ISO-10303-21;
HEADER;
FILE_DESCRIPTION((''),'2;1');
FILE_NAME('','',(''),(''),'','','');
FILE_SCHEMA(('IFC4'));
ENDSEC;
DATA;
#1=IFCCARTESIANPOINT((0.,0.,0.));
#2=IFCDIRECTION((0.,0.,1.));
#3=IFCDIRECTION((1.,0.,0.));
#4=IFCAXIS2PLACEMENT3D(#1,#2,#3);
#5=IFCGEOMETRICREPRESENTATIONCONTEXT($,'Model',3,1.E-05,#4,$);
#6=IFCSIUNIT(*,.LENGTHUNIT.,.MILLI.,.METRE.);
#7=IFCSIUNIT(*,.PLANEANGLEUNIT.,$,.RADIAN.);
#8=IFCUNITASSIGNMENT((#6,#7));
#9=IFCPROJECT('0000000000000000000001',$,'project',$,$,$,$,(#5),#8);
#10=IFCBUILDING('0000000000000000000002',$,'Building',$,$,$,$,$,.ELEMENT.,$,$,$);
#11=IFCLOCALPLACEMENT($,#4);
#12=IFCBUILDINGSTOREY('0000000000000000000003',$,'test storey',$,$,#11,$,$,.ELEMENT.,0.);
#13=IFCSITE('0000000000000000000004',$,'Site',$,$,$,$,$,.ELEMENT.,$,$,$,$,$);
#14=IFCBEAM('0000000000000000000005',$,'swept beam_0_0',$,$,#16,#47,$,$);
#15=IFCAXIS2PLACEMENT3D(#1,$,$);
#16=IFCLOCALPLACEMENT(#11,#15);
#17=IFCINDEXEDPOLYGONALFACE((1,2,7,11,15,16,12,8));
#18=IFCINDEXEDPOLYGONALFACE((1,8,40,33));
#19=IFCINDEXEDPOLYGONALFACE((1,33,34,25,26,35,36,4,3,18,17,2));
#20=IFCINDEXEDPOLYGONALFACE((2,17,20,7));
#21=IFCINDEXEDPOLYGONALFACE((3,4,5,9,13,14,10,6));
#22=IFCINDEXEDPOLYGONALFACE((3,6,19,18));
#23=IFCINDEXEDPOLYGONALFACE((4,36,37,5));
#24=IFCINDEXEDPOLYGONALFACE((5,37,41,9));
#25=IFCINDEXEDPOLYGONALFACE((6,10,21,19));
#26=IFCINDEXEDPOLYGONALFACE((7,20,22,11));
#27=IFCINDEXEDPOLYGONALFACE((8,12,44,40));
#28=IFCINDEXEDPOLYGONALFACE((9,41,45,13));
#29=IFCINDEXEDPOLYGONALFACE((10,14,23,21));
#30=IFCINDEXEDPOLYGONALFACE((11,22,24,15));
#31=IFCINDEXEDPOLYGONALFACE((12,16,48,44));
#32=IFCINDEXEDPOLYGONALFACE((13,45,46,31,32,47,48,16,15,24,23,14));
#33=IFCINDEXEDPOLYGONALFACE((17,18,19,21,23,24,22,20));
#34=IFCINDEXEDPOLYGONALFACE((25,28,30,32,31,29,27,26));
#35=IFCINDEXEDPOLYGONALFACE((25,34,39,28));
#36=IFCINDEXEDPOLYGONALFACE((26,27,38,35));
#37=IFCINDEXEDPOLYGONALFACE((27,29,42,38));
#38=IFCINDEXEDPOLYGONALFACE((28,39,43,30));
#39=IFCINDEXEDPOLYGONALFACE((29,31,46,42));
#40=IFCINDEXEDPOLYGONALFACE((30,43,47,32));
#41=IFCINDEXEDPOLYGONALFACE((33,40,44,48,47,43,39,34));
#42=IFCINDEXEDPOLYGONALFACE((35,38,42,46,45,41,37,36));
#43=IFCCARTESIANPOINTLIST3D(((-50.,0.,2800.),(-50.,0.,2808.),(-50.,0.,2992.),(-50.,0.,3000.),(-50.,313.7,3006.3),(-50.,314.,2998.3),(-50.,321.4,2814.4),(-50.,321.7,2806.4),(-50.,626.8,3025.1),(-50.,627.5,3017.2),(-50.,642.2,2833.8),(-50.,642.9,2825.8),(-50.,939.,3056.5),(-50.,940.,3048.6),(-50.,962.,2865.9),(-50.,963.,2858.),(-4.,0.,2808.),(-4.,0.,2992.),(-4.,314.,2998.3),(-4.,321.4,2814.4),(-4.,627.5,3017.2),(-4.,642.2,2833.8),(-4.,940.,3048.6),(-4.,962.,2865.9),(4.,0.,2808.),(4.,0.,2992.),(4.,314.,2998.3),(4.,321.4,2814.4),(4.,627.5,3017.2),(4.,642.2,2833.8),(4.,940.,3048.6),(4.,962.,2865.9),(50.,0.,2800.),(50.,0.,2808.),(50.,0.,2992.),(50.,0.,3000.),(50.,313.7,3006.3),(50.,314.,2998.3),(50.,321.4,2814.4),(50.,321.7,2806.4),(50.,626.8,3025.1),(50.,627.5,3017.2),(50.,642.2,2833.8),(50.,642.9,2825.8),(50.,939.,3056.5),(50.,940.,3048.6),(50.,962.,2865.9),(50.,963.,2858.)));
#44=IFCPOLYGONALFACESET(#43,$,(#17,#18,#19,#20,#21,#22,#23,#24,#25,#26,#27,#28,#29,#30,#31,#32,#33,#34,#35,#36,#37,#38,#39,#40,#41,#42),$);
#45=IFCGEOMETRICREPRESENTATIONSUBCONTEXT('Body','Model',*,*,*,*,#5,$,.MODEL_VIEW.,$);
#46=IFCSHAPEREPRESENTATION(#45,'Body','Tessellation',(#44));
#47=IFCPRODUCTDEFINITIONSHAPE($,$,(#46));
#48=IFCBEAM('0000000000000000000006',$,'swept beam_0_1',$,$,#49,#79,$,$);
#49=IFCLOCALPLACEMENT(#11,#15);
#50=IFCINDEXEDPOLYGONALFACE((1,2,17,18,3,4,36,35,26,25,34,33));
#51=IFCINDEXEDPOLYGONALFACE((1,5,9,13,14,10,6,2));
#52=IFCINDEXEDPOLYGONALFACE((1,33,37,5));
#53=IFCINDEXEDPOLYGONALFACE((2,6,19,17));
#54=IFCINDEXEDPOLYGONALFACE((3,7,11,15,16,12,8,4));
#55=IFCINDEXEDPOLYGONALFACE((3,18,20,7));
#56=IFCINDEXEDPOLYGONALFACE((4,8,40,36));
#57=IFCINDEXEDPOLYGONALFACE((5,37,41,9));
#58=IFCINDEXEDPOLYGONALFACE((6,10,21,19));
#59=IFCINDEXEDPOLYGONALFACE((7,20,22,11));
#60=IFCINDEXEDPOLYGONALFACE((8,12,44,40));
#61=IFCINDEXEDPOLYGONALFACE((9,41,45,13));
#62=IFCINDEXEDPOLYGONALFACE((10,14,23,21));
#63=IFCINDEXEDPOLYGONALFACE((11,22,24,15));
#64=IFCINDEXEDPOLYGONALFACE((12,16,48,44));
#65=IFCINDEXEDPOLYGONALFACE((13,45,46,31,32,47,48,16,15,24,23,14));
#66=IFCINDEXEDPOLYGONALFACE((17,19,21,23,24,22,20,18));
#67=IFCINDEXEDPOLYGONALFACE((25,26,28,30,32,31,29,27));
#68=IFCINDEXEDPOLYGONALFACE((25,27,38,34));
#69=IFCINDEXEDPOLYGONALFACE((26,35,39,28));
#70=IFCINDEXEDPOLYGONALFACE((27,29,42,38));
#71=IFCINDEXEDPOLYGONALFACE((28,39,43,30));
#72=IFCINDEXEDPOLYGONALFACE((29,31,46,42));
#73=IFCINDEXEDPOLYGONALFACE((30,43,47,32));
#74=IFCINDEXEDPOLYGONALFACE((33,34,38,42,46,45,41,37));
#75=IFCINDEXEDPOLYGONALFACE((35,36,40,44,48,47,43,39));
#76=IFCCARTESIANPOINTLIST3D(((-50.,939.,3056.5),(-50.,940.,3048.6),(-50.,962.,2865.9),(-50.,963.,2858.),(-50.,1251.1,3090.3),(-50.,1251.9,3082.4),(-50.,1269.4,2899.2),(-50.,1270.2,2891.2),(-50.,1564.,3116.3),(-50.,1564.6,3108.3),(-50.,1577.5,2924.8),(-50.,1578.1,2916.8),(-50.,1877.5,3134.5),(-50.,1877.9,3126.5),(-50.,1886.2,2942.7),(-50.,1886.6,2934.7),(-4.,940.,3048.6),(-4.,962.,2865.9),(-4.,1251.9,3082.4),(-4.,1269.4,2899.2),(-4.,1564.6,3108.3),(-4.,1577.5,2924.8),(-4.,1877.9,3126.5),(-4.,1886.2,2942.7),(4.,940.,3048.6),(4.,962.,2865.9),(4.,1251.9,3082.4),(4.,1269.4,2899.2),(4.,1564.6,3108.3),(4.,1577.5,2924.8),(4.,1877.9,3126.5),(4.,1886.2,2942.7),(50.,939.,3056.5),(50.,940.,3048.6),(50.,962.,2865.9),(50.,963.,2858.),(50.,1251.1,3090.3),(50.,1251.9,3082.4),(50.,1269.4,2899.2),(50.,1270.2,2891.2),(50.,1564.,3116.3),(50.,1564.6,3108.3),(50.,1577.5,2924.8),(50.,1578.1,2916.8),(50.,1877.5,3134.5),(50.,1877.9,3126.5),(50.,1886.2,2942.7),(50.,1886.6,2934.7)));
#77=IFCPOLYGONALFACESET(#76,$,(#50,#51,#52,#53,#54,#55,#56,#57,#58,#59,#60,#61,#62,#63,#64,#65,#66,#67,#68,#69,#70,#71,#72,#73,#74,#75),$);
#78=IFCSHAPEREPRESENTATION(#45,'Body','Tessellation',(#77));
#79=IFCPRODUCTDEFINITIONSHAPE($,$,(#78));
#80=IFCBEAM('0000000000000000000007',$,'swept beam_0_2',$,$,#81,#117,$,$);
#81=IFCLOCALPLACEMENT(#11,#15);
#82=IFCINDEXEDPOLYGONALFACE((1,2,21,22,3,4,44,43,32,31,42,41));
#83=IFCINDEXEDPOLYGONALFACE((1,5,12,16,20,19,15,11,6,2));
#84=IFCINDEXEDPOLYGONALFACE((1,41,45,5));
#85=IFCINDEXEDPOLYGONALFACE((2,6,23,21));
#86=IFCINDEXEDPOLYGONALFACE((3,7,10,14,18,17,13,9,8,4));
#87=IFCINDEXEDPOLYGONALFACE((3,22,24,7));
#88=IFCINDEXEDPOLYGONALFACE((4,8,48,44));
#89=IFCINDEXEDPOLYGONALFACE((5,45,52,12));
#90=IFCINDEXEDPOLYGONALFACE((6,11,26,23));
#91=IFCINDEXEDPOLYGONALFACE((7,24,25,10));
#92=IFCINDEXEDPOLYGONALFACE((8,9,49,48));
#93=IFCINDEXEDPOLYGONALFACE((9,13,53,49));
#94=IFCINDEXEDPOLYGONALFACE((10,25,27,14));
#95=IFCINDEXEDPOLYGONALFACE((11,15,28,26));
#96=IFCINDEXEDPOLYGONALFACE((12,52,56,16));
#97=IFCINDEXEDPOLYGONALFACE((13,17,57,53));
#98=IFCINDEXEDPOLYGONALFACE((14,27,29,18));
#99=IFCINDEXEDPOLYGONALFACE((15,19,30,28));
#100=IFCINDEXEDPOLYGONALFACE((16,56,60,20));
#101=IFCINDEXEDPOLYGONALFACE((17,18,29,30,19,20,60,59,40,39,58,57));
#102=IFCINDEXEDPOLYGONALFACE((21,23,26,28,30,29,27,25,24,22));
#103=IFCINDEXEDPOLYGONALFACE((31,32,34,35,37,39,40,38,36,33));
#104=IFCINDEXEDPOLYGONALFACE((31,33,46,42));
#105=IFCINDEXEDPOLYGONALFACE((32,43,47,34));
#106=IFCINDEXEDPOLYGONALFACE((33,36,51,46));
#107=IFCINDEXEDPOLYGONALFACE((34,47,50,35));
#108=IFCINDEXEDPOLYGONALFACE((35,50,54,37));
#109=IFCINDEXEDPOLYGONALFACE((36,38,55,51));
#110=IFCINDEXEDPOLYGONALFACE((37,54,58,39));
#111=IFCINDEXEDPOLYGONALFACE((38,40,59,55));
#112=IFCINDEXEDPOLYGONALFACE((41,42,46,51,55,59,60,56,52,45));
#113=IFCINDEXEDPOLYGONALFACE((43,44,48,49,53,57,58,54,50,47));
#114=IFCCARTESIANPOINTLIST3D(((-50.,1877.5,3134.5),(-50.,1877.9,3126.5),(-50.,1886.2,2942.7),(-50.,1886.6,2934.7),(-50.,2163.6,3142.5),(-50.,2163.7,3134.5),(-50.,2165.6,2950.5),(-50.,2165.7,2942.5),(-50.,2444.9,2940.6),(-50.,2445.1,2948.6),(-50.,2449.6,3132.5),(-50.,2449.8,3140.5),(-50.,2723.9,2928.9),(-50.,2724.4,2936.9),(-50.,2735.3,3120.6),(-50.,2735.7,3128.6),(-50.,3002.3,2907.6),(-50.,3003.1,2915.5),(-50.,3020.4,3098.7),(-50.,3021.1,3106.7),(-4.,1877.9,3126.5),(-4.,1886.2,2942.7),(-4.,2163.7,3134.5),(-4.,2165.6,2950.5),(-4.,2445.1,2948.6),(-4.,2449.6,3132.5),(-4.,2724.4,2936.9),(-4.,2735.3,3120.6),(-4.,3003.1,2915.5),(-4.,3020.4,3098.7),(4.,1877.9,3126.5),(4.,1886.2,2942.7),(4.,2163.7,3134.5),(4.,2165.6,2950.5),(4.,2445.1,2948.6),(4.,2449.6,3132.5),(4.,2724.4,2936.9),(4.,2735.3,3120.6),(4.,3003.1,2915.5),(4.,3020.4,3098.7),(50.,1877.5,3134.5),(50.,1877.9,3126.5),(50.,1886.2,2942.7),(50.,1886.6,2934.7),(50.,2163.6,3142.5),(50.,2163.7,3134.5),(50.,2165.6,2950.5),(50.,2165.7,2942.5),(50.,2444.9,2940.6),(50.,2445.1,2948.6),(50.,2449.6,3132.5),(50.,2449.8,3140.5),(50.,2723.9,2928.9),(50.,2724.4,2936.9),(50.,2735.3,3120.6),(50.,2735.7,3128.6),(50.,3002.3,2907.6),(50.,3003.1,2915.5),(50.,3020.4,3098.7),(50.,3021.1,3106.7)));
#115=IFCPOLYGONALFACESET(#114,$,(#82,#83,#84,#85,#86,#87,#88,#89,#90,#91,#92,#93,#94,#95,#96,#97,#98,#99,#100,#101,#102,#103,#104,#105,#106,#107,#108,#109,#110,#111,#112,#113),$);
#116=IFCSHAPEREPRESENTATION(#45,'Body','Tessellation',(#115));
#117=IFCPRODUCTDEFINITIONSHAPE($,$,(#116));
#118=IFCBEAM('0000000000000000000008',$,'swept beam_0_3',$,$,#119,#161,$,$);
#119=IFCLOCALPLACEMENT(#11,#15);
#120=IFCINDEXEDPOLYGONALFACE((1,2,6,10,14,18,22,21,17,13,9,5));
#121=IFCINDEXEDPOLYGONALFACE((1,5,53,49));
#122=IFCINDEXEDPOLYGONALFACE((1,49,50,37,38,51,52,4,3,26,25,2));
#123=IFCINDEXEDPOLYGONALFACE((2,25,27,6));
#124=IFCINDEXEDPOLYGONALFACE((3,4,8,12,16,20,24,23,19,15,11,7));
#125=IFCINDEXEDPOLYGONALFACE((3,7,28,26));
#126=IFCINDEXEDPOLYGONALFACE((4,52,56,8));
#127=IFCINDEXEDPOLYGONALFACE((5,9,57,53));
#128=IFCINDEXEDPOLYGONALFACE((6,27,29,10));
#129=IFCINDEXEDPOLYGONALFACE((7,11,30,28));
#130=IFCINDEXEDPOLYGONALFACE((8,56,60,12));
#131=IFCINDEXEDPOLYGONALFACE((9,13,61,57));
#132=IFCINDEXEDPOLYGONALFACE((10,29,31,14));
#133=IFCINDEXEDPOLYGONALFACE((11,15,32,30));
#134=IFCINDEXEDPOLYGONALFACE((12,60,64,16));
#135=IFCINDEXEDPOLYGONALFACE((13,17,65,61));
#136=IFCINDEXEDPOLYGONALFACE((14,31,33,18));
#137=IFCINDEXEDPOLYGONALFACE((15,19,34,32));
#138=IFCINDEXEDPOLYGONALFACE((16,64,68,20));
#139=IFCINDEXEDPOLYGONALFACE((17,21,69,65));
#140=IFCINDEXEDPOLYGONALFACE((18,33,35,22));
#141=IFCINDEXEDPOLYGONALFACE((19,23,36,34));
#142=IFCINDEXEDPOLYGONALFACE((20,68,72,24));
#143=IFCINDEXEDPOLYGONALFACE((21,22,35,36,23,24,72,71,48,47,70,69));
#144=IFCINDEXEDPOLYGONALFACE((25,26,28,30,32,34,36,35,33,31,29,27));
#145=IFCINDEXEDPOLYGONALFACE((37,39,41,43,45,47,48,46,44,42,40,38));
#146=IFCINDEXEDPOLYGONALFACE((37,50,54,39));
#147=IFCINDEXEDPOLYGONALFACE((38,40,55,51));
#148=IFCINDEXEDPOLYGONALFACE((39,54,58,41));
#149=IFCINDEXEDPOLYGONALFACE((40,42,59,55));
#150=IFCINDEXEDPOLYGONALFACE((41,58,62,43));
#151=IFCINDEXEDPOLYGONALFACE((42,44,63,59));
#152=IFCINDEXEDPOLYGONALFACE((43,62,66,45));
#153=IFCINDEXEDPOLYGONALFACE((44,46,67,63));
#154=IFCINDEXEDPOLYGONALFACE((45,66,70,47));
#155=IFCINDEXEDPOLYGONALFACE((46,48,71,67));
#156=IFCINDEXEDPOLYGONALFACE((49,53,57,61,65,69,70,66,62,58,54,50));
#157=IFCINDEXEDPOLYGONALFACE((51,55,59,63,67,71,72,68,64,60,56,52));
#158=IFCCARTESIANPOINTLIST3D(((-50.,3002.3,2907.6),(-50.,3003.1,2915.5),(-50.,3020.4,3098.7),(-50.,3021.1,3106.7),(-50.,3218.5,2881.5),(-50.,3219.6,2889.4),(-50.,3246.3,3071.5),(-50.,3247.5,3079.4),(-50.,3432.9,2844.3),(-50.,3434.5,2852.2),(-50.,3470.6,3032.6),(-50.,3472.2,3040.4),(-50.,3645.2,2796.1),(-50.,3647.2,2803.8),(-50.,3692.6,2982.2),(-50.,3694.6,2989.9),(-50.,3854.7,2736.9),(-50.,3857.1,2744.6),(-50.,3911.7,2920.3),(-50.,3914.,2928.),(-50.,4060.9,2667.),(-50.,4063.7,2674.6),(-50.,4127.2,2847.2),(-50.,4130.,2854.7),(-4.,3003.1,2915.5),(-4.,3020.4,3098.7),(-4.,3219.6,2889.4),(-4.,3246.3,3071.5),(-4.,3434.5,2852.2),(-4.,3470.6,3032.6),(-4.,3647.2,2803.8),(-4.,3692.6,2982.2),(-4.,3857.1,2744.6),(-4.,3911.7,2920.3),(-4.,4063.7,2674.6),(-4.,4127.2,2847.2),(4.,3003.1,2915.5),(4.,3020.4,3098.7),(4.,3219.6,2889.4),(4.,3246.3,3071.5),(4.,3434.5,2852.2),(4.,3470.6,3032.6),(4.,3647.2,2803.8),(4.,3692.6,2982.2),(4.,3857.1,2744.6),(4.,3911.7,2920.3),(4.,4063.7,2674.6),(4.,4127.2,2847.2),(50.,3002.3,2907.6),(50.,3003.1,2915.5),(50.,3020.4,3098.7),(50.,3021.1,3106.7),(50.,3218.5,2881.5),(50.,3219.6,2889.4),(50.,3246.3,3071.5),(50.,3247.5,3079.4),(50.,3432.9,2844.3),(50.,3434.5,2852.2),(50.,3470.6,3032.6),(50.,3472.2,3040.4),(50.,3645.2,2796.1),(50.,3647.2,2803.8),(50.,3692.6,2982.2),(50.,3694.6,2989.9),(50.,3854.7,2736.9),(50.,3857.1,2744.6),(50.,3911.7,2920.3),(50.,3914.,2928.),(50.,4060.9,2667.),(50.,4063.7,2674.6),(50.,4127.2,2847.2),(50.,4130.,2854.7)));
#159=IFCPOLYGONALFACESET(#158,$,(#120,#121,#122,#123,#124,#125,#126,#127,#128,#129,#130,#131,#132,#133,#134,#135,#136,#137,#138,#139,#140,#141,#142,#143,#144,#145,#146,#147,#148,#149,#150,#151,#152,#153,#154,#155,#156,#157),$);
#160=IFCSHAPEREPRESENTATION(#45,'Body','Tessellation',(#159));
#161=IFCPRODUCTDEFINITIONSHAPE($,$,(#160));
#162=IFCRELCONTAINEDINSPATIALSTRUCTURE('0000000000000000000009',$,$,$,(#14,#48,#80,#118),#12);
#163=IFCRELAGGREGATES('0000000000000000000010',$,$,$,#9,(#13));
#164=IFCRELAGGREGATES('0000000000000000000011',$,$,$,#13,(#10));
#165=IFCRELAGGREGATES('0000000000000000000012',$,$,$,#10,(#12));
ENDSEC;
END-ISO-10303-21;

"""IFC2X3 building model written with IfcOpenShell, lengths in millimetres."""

from ifc_helpers import new_model, entity, si_unit, origin_with_axes, place, context, subcontext, project, spatial, element, save


model = new_model("IFC2X3")

# Units and contexts
model_context = context("Model", 3, precision=1e-05, world=origin_with_axes())
body_context = subcontext(model_context, "Body", "Model", "MODEL_VIEW")
ifc_project = project(units=[si_unit("LENGTHUNIT", "METRE", prefix="MILLI"), si_unit("PLANEANGLEUNIT", "RADIAN")], contexts=[model_context])

# Site, building, storey
site = spatial("IfcSite", under=ifc_project, Name="Site", CompositionType="ELEMENT")
building = spatial("IfcBuilding", under=site, Name="Building", CompositionType="ELEMENT")
storey_placement = place(None, origin_with_axes())
storey = spatial("IfcBuildingStorey", under=building, at=storey_placement, Name="test storey", CompositionType="ELEMENT", Elevation=0.0)

# Beams
beam_1_placement = place(storey_placement, origin_with_axes())
element("IfcBeam", 1, at=beam_1_placement, inside=storey, Name="swept beam_0_0", context=body_context, shape_type="SweptSolid", body=[
    entity("IfcRevolvedAreaSolid", entity("IfcArbitraryClosedProfileDef", "AREA", None, entity("IfcPolyline", [entity("IfcCartesianPoint", [192.0, 50.0]), entity("IfcCartesianPoint", [192.0, 4.0]), entity("IfcCartesianPoint", [8.0, 4.0]), entity("IfcCartesianPoint", [8.0, 50.0]), entity("IfcCartesianPoint", [0.0, 50.0]), entity("IfcCartesianPoint", [0.0, -50.0]), entity("IfcCartesianPoint", [8.0, -50.0]), entity("IfcCartesianPoint", [8.0, -4.0]), entity("IfcCartesianPoint", [192.0, -4.0]), entity("IfcCartesianPoint", [192.0, -50.0]), entity("IfcCartesianPoint", [200.0, -50.0]), entity("IfcCartesianPoint", [200.0, 50.0]), entity("IfcCartesianPoint", [192.0, 50.0])])), entity("IfcAxis2Placement3D", entity("IfcCartesianPoint", [0.0, 0.0, 3000.0]), entity("IfcDirection", [0.0, -1.0, 0.0]), entity("IfcDirection", [0.0, 0.0, -1.0])), entity("IfcAxis1Placement", entity("IfcCartesianPoint", [-7825.6, 0.0, 0.0]), entity("IfcDirection", [0.0, 1.0, 0.0])), 0.12028),
])
beam_2_placement = place(storey_placement, origin_with_axes())
element("IfcBeam", 2, at=beam_2_placement, inside=storey, Name="swept beam_0_1", context=body_context, shape_type="SweptSolid", body=[
    entity("IfcRevolvedAreaSolid", entity("IfcArbitraryClosedProfileDef", "AREA", None, entity("IfcPolyline", [entity("IfcCartesianPoint", [-192.0, -50.0]), entity("IfcCartesianPoint", [-192.0, -4.0]), entity("IfcCartesianPoint", [-8.0, -4.0]), entity("IfcCartesianPoint", [-8.0, -50.0]), entity("IfcCartesianPoint", [0.0, -50.0]), entity("IfcCartesianPoint", [0.0, 50.0]), entity("IfcCartesianPoint", [-8.0, 50.0]), entity("IfcCartesianPoint", [-8.0, 4.0]), entity("IfcCartesianPoint", [-192.0, 4.0]), entity("IfcCartesianPoint", [-192.0, 50.0]), entity("IfcCartesianPoint", [-200.0, 50.0]), entity("IfcCartesianPoint", [-200.0, -50.0]), entity("IfcCartesianPoint", [-192.0, -50.0])])), entity("IfcAxis2Placement3D", entity("IfcCartesianPoint", [0.0, 939.0, 3056.5]), entity("IfcDirection", [0.0, -0.9928, -0.12]), entity("IfcDirection", [0.0, -0.12, 0.9928])), entity("IfcAxis1Placement", entity("IfcCartesianPoint", [-12581.5, 0.0, 0.0]), entity("IfcDirection", [0.0, 1.0, 0.0])), 0.074868),
])
beam_3_placement = place(storey_placement, origin_with_axes())
element("IfcBeam", 3, at=beam_3_placement, inside=storey, Name="swept beam_0_2", context=body_context, shape_type="SweptSolid", body=[
    entity("IfcRevolvedAreaSolid", entity("IfcArbitraryClosedProfileDef", "AREA", None, entity("IfcPolyline", [entity("IfcCartesianPoint", [-192.0, -50.0]), entity("IfcCartesianPoint", [-192.0, -4.0]), entity("IfcCartesianPoint", [-8.0, -4.0]), entity("IfcCartesianPoint", [-8.0, -50.0]), entity("IfcCartesianPoint", [0.0, -50.0]), entity("IfcCartesianPoint", [0.0, 50.0]), entity("IfcCartesianPoint", [-8.0, 50.0]), entity("IfcCartesianPoint", [-8.0, 4.0]), entity("IfcCartesianPoint", [-192.0, 4.0]), entity("IfcCartesianPoint", [-192.0, 50.0]), entity("IfcCartesianPoint", [-200.0, 50.0]), entity("IfcCartesianPoint", [-200.0, -50.0]), entity("IfcCartesianPoint", [-192.0, -50.0])])), entity("IfcAxis2Placement3D", entity("IfcCartesianPoint", [0.0, 1877.5, 3134.5]), entity("IfcDirection", [0.0, -0.999, -0.0454]), entity("IfcDirection", [0.0, -0.0454, 0.999])), entity("IfcAxis1Placement", entity("IfcCartesianPoint", [-8211.3, 0.0, 0.0]), entity("IfcDirection", [0.0, 1.0, 0.0])), 0.139427),
])
beam_4_placement = place(storey_placement, origin_with_axes())
element("IfcBeam", 4, at=beam_4_placement, inside=storey, Name="swept beam_0_3", context=body_context, shape_type="SweptSolid", body=[
    entity("IfcRevolvedAreaSolid", entity("IfcArbitraryClosedProfileDef", "AREA", None, entity("IfcPolyline", [entity("IfcCartesianPoint", [-192.0, -50.0]), entity("IfcCartesianPoint", [-192.0, -4.0]), entity("IfcCartesianPoint", [-8.0, -4.0]), entity("IfcCartesianPoint", [-8.0, -50.0]), entity("IfcCartesianPoint", [0.0, -50.0]), entity("IfcCartesianPoint", [0.0, 50.0]), entity("IfcCartesianPoint", [-8.0, 50.0]), entity("IfcCartesianPoint", [-8.0, 4.0]), entity("IfcCartesianPoint", [-192.0, 4.0]), entity("IfcCartesianPoint", [-192.0, 50.0]), entity("IfcCartesianPoint", [-200.0, 50.0]), entity("IfcCartesianPoint", [-200.0, -50.0]), entity("IfcCartesianPoint", [-192.0, -50.0])])), entity("IfcAxis2Placement3D", entity("IfcCartesianPoint", [0.0, 3021.1, 3106.7]), entity("IfcDirection", [0.0, -0.9956, 0.0939]), entity("IfcDirection", [0.0, 0.0939, 0.9956])), entity("IfcAxis1Placement", entity("IfcCartesianPoint", [-4407.0, 0.0, 0.0]), entity("IfcDirection", [0.0, 1.0, 0.0])), 0.258751),
])

save(model, "model.ifc")
